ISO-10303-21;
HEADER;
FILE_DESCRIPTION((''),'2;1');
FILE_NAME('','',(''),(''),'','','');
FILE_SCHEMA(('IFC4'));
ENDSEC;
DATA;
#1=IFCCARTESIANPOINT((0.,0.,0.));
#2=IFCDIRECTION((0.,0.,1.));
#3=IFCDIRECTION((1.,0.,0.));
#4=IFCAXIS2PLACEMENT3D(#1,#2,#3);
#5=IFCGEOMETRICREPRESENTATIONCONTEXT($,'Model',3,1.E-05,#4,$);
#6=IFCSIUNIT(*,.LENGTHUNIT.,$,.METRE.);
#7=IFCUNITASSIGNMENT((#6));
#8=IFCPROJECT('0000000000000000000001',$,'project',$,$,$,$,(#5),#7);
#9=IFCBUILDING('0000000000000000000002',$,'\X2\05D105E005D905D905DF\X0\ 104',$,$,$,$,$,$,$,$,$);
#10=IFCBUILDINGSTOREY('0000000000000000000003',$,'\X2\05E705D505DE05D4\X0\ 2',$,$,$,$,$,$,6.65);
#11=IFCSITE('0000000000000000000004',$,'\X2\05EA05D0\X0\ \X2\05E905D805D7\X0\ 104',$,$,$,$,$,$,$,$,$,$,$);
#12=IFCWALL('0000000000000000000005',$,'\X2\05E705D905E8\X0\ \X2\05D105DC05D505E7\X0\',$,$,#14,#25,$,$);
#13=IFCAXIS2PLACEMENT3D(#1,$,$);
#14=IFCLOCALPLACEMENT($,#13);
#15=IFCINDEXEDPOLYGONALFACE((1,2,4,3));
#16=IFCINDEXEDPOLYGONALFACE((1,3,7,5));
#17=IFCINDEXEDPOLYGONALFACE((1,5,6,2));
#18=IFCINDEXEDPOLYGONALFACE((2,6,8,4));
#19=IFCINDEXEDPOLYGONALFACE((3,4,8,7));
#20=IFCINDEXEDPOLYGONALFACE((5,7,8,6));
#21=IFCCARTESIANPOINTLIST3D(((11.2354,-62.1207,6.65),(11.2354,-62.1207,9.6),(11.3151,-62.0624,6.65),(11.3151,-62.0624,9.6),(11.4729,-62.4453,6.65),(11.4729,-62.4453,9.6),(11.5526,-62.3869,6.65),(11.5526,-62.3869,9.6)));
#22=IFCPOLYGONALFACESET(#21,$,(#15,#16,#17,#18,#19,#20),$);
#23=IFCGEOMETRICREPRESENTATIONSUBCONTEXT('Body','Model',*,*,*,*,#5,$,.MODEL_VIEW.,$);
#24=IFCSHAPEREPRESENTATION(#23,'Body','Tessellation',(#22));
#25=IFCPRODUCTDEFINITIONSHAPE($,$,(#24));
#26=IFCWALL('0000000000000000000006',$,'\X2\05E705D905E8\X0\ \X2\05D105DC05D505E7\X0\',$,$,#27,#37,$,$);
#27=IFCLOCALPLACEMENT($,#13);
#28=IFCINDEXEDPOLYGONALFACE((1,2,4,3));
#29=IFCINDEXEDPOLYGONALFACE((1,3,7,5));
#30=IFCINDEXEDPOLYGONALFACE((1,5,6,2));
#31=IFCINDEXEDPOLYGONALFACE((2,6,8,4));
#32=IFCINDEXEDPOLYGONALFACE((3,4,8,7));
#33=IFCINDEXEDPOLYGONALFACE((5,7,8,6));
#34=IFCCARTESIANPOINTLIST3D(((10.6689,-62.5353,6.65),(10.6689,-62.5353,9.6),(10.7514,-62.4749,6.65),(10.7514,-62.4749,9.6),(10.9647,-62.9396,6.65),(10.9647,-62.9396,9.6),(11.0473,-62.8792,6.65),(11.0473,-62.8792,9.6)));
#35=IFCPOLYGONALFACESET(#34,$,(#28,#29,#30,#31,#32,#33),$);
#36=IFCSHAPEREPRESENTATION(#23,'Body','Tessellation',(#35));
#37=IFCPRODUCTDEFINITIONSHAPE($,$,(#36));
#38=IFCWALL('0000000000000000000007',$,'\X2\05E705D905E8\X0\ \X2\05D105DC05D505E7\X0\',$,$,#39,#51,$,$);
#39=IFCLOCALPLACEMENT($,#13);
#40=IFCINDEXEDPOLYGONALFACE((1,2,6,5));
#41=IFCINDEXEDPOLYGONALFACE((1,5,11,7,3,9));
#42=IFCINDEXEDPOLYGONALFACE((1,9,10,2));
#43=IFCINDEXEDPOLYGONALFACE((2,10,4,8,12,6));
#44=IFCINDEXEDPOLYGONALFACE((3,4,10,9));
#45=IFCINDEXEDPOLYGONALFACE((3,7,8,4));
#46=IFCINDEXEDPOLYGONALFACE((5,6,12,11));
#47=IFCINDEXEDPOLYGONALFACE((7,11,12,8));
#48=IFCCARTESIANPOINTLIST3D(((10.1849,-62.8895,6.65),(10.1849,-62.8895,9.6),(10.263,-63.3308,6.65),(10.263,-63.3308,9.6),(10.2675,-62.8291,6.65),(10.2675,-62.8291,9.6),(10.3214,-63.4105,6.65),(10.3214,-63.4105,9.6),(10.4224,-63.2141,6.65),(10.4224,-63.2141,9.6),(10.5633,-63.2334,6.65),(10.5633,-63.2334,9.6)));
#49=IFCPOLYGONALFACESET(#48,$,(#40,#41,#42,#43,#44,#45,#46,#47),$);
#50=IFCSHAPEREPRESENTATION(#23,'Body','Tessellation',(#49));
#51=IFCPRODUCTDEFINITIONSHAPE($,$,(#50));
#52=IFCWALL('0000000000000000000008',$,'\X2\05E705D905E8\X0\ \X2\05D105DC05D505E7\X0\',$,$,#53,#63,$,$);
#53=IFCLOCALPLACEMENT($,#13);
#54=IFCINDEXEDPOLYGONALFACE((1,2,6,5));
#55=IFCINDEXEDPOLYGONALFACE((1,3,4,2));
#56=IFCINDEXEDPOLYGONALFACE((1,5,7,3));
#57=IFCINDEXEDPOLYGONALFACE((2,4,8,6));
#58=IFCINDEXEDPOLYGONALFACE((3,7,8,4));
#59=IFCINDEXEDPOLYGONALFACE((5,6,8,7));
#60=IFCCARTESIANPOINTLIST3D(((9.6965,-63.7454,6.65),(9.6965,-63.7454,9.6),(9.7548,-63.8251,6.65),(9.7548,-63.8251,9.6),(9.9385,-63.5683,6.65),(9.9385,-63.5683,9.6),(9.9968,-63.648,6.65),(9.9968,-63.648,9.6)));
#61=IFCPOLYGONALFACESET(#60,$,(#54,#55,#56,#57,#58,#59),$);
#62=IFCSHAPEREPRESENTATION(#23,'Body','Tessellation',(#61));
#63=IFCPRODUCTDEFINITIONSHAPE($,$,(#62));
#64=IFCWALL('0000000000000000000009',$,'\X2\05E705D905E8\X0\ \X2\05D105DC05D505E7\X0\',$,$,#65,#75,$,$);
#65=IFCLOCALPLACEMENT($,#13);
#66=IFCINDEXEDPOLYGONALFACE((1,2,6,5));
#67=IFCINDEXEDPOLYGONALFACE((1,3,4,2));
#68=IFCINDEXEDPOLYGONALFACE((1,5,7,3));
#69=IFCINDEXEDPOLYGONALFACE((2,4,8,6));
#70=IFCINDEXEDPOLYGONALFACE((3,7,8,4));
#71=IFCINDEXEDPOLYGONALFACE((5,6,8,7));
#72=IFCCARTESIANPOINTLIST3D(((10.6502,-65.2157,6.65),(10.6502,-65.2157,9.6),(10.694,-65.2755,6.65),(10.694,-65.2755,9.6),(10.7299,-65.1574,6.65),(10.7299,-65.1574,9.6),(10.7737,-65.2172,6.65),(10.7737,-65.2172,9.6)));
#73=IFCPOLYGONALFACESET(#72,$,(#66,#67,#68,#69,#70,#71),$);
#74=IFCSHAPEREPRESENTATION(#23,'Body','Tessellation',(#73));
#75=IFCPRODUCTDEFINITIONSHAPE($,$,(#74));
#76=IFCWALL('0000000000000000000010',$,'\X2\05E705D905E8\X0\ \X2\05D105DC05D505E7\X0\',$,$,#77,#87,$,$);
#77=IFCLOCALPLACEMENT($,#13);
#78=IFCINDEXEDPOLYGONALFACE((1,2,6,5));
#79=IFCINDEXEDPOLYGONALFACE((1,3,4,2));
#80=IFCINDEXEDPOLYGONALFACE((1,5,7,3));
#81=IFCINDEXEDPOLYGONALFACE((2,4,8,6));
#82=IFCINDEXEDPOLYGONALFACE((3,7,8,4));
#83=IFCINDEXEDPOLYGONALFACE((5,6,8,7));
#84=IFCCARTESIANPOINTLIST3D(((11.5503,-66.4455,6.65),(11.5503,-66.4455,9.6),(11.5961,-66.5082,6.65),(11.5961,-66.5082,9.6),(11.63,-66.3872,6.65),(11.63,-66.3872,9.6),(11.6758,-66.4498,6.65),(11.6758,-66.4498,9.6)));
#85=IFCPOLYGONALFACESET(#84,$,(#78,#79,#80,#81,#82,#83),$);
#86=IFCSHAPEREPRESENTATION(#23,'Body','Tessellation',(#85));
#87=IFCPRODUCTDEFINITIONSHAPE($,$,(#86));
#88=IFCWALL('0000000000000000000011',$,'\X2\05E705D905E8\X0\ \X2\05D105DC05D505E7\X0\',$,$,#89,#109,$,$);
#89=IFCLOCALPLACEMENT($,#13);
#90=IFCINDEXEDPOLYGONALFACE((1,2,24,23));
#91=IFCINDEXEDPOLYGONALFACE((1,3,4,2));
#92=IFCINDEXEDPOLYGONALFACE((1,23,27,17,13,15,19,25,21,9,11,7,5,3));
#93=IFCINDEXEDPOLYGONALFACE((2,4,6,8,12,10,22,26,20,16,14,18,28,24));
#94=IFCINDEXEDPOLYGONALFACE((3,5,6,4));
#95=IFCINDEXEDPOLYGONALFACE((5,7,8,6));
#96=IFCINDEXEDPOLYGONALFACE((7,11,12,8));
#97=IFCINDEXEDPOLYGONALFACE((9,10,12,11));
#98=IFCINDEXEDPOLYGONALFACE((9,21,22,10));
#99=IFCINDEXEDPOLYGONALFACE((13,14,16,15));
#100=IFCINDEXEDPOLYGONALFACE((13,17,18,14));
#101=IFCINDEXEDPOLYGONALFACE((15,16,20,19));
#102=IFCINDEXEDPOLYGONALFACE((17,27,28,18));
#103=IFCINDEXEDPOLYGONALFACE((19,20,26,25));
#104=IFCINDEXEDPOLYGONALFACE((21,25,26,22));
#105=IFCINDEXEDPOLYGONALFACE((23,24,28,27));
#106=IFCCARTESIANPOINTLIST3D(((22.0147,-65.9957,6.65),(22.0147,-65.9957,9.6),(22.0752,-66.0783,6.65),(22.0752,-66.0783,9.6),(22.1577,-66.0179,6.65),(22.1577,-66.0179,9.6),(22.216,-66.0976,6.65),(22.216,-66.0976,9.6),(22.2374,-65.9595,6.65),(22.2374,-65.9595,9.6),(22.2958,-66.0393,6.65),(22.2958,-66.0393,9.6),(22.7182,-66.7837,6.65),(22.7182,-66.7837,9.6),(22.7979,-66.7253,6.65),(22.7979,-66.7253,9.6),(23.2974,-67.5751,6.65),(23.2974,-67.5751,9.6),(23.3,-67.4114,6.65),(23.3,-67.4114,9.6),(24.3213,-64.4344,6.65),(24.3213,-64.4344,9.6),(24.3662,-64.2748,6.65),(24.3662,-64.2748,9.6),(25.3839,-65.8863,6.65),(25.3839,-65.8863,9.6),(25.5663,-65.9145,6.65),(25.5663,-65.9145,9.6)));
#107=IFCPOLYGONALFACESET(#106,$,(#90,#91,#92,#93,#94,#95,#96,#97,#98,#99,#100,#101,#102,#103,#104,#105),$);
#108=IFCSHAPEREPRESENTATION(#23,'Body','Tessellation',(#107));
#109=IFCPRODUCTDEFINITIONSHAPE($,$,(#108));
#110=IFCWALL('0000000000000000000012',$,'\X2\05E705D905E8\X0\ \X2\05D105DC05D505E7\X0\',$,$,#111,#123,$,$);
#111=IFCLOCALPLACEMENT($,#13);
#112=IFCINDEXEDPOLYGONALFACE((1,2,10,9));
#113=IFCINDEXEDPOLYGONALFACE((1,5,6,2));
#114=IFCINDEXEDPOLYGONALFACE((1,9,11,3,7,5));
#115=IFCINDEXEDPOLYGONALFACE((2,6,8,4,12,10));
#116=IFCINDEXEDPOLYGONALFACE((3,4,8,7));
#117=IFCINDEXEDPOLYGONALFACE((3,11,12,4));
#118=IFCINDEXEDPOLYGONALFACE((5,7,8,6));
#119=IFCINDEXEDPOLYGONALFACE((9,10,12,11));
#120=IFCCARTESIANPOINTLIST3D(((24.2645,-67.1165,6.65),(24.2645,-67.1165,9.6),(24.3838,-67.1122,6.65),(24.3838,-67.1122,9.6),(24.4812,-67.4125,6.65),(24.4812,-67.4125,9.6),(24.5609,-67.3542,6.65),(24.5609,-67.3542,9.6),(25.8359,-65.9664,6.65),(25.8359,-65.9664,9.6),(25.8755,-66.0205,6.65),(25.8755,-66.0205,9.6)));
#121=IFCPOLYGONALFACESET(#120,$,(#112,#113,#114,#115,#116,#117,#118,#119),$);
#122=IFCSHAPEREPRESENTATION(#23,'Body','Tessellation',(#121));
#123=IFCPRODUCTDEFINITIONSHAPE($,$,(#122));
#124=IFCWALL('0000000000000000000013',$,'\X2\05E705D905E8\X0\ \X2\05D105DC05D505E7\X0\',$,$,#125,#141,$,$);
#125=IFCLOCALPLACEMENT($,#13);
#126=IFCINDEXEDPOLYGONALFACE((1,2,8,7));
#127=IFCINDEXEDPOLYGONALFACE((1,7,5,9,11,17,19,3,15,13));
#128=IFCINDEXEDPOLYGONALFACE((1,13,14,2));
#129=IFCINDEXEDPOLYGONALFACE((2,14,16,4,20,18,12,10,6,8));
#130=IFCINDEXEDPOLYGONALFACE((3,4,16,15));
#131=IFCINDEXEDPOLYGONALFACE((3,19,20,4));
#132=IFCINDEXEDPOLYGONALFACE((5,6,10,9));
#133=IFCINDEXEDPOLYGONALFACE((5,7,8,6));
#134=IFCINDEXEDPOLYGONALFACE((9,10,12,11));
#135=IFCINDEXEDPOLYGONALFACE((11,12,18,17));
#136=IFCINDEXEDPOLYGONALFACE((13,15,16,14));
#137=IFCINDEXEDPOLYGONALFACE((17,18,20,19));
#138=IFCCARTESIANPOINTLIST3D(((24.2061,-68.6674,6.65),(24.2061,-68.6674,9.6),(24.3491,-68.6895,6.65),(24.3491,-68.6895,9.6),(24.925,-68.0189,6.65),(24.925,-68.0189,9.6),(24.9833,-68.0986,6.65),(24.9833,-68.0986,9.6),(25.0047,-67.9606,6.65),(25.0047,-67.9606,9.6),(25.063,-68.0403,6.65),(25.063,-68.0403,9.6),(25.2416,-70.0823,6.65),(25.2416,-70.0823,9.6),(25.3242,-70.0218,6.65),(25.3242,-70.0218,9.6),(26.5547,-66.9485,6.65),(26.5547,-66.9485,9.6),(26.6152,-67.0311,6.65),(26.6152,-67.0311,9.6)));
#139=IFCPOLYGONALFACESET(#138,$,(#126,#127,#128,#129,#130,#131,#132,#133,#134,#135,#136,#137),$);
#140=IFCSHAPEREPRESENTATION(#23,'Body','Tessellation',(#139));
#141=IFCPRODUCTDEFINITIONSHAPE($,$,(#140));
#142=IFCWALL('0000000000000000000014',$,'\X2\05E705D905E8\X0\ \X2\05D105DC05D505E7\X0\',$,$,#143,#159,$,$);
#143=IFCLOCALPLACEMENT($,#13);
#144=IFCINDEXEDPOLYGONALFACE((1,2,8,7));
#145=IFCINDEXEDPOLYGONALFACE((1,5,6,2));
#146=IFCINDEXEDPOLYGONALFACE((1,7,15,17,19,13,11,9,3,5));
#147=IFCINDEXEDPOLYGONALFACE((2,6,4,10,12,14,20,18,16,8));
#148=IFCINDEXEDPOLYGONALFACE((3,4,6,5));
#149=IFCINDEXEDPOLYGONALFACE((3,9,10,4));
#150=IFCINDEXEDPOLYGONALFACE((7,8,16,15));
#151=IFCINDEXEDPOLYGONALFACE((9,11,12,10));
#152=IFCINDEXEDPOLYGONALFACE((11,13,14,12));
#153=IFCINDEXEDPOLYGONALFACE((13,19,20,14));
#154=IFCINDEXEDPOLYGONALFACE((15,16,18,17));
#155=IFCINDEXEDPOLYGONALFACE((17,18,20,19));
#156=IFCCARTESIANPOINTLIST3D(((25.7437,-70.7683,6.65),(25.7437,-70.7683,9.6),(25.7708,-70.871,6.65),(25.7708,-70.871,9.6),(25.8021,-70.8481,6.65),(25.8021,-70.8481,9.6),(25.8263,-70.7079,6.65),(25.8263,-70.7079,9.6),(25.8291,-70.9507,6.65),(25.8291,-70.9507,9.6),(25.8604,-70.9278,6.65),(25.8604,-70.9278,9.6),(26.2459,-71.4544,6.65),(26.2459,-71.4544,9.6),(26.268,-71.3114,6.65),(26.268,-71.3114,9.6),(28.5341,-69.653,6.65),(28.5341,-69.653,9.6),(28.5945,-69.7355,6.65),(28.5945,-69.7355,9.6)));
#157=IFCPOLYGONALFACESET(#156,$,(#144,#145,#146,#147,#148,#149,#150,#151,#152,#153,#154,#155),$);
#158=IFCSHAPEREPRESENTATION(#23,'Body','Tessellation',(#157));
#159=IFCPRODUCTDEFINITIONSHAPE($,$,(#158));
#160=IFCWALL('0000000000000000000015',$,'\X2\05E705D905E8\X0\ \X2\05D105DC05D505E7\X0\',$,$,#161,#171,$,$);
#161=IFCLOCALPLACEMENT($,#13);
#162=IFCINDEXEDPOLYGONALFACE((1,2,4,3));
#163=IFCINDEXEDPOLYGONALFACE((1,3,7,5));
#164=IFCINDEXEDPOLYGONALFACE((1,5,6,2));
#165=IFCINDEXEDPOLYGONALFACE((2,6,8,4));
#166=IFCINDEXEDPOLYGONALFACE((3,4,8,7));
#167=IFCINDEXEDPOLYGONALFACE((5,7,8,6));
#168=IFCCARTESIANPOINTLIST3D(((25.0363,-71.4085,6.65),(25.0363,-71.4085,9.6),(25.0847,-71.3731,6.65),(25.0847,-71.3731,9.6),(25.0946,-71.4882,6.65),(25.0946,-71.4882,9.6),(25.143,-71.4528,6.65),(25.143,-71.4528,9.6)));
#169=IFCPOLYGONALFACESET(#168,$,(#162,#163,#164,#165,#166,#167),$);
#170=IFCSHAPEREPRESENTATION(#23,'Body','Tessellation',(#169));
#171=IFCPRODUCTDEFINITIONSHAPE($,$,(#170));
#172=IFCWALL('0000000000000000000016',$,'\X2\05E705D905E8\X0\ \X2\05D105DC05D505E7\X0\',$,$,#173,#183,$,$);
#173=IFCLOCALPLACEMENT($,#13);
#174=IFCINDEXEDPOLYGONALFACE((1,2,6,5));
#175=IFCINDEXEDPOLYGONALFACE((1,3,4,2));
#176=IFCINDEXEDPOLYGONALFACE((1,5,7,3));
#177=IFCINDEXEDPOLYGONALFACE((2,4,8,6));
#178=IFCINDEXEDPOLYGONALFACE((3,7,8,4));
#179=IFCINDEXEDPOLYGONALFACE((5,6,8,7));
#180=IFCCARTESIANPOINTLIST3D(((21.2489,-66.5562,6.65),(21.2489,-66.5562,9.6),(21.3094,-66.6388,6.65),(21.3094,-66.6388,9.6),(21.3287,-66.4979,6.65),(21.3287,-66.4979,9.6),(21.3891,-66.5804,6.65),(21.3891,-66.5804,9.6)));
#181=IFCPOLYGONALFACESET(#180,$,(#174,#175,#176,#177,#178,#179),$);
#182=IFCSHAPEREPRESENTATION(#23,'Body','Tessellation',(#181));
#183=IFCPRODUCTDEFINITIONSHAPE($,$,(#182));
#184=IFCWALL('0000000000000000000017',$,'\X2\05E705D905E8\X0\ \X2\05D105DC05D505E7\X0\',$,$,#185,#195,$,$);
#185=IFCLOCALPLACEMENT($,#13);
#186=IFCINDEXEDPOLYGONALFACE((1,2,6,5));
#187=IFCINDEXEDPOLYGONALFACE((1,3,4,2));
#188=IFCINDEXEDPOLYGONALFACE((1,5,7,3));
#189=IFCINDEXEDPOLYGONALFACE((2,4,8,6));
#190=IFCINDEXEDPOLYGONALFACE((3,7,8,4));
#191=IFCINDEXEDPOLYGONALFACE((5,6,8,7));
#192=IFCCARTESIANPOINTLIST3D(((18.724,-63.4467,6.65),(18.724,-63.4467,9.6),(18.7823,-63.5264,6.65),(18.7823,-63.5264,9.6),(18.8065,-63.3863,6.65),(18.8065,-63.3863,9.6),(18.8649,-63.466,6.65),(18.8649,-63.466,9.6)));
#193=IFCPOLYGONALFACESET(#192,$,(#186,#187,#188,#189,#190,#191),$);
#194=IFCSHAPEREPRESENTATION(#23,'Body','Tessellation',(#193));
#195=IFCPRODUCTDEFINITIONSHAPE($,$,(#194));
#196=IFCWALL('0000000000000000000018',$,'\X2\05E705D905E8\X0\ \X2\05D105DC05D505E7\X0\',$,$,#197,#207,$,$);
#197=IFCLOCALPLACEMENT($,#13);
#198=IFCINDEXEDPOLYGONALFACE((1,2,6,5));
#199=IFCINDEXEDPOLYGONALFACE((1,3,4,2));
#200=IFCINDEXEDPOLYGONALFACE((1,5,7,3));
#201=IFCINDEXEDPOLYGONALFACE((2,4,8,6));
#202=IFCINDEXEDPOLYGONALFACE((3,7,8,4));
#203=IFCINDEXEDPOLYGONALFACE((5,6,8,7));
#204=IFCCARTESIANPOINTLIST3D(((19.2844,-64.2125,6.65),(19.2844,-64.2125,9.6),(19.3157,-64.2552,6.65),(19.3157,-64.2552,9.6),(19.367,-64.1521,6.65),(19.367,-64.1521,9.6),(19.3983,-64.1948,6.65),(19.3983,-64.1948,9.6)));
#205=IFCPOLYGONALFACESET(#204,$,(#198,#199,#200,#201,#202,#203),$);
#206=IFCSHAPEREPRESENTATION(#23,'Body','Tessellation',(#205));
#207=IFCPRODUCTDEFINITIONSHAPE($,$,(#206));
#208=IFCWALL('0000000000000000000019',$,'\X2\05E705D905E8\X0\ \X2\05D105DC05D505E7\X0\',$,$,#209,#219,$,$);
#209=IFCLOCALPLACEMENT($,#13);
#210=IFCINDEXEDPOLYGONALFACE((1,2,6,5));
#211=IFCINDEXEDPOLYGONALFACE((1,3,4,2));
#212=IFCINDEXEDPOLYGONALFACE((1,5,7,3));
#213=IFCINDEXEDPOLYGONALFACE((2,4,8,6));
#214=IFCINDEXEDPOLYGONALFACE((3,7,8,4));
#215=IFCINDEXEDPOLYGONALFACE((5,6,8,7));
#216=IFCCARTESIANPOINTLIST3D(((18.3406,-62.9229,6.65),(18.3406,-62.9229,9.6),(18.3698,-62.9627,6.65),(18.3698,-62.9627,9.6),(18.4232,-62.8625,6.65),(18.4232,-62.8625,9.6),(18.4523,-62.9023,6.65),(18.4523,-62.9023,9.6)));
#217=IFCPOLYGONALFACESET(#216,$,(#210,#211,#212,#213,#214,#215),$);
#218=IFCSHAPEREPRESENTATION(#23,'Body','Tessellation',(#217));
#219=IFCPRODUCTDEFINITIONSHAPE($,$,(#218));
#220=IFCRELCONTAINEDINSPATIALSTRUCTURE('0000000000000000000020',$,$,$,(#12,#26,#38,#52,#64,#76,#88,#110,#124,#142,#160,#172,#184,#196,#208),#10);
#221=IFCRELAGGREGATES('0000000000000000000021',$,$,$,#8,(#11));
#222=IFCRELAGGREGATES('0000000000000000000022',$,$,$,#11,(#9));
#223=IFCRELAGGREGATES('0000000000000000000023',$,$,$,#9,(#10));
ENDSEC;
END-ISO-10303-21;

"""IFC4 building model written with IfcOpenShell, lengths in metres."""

from ifc_helpers import new_model, si_unit, frame, origin_with_axes, context, subcontext, project, spatial, polyline, outline, extrude, element, save


model = new_model("IFC4")

# Units and contexts
model_context = context("Model", 3, precision=1e-05, world=origin_with_axes())
body_context = subcontext(model_context, "Body", "Model", "MODEL_VIEW")
ifc_project = project(units=[si_unit("LENGTHUNIT", "METRE")], contexts=[model_context])

# Site, building, storey
site = spatial("IfcSite", under=ifc_project, Name="תא שטח 104")
building = spatial("IfcBuilding", under=site, Name="בניין 104")
storey = spatial("IfcBuildingStorey", under=building, Name="קומה 2", Elevation=6.65)

# Walls
element("IfcWall", 1, inside=storey, Name="קיר בלוק", context=body_context, shape_type="SweptSolid", body=[
    extrude(outline(polyline([(11.3151, -62.0624), (11.2354, -62.1207), (11.4729, -62.4453), (11.5526, -62.3869), (11.3151, -62.0624)])), frame((0.0, 0.0, 6.65)), (0.0, 0.0, 1.0), 2.95),
])
element("IfcWall", 2, inside=storey, Name="קיר בלוק", context=body_context, shape_type="SweptSolid", body=[
    extrude(outline(polyline([(10.6689, -62.5353), (10.9647, -62.9396), (11.0473, -62.8792), (10.7514, -62.4749), (10.6689, -62.5353)])), frame((0.0, 0.0, 6.65)), (0.0, 0.0, 1.0), 2.95),
])
element("IfcWall", 3, inside=storey, Name="קיר בלוק", context=body_context, shape_type="SweptSolid", body=[
    extrude(outline(polyline([(10.1849, -62.8895), (10.4224, -63.2141), (10.263, -63.3308), (10.3214, -63.4105), (10.5633, -63.2334), (10.2675, -62.8291), (10.1849, -62.8895)])), frame((0.0, 0.0, 6.65)), (0.0, 0.0, 1.0), 2.95),
])
element("IfcWall", 4, inside=storey, Name="קיר בלוק", context=body_context, shape_type="SweptSolid", body=[
    extrude(outline(polyline([(9.9968, -63.648), (9.9385, -63.5683), (9.6965, -63.7454), (9.7548, -63.8251), (9.9968, -63.648)])), frame((0.0, 0.0, 6.65)), (0.0, 0.0, 1.0), 2.95),
])
element("IfcWall", 5, inside=storey, Name="קיר בלוק", context=body_context, shape_type="SweptSolid", body=[
    extrude(outline(polyline([(10.7737, -65.2172), (10.7299, -65.1574), (10.6502, -65.2157), (10.694, -65.2755), (10.7737, -65.2172)])), frame((0.0, 0.0, 6.65)), (0.0, 0.0, 1.0), 2.95),
])
element("IfcWall", 6, inside=storey, Name="קיר בלוק", context=body_context, shape_type="SweptSolid", body=[
    extrude(outline(polyline([(11.6758, -66.4498), (11.63, -66.3872), (11.5503, -66.4455), (11.5961, -66.5082), (11.6758, -66.4498)])), frame((0.0, 0.0, 6.65)), (0.0, 0.0, 1.0), 2.95),
])
element("IfcWall", 7, inside=storey, Name="קיר בלוק", context=body_context, shape_type="SweptSolid", body=[
    extrude(outline(polyline([(22.7979, -66.7253), (22.7182, -66.7837), (23.2974, -67.5751), (25.5663, -65.9145), (24.3662, -64.2748), (22.0147, -65.9957), (22.0752, -66.0783), (22.1577, -66.0179), (22.216, -66.0976), (22.2958, -66.0393), (22.2374, -65.9595), (24.3213, -64.4344), (25.3839, -65.8863), (23.3, -67.4114), (22.7979, -66.7253)])), frame((0.0, 0.0, 6.65)), (0.0, 0.0, 1.0), 2.95),
])
element("IfcWall", 8, inside=storey, Name="קיר בלוק", context=body_context, shape_type="SweptSolid", body=[
    extrude(outline(polyline([(24.2645, -67.1165), (24.4812, -67.4125), (24.5609, -67.3542), (24.3838, -67.1122), (25.8755, -66.0205), (25.8359, -65.9664), (24.2645, -67.1165)])), frame((0.0, 0.0, 6.65)), (0.0, 0.0, 1.0), 2.95),
])
element("IfcWall", 9, inside=storey, Name="קיר בלוק", context=body_context, shape_type="SweptSolid", body=[
    extrude(outline(polyline([(24.9833, -68.0986), (24.2061, -68.6674), (25.2416, -70.0823), (25.3242, -70.0218), (24.3491, -68.6895), (26.6152, -67.0311), (26.5547, -66.9485), (25.063, -68.0403), (25.0047, -67.9606), (24.925, -68.0189), (24.9833, -68.0986)])), frame((0.0, 0.0, 6.65)), (0.0, 0.0, 1.0), 2.95),
])
element("IfcWall", 10, inside=storey, Name="קיר בלוק", context=body_context, shape_type="SweptSolid", body=[
    extrude(outline(polyline([(25.8604, -70.9278), (26.2459, -71.4544), (28.5945, -69.7355), (28.5341, -69.653), (26.268, -71.3114), (25.8263, -70.7079), (25.7437, -70.7683), (25.8021, -70.8481), (25.7708, -70.871), (25.8291, -70.9507), (25.8604, -70.9278)])), frame((0.0, 0.0, 6.65)), (0.0, 0.0, 1.0), 2.95),
])
element("IfcWall", 11, inside=storey, Name="קיר בלוק", context=body_context, shape_type="SweptSolid", body=[
    extrude(outline(polyline([(25.0847, -71.3731), (25.0363, -71.4085), (25.0946, -71.4882), (25.143, -71.4528), (25.0847, -71.3731)])), frame((0.0, 0.0, 6.65)), (0.0, 0.0, 1.0), 2.95),
])
element("IfcWall", 12, inside=storey, Name="קיר בלוק", context=body_context, shape_type="SweptSolid", body=[
    extrude(outline(polyline([(21.3891, -66.5804), (21.3287, -66.4979), (21.2489, -66.5562), (21.3094, -66.6388), (21.3891, -66.5804)])), frame((0.0, 0.0, 6.65)), (0.0, 0.0, 1.0), 2.95),
])
element("IfcWall", 13, inside=storey, Name="קיר בלוק", context=body_context, shape_type="SweptSolid", body=[
    extrude(outline(polyline([(18.7823, -63.5264), (18.8649, -63.466), (18.8065, -63.3863), (18.724, -63.4467), (18.7823, -63.5264)])), frame((0.0, 0.0, 6.65)), (0.0, 0.0, 1.0), 2.95),
])
element("IfcWall", 14, inside=storey, Name="קיר בלוק", context=body_context, shape_type="SweptSolid", body=[
    extrude(outline(polyline([(19.3983, -64.1948), (19.367, -64.1521), (19.2844, -64.2125), (19.3157, -64.2552), (19.3983, -64.1948)])), frame((0.0, 0.0, 6.65)), (0.0, 0.0, 1.0), 2.95),
])
element("IfcWall", 15, inside=storey, Name="קיר בלוק", context=body_context, shape_type="SweptSolid", body=[
    extrude(outline(polyline([(18.3406, -62.9229), (18.3698, -62.9627), (18.4523, -62.9023), (18.4232, -62.8625), (18.3406, -62.9229)])), frame((0.0, 0.0, 6.65)), (0.0, 0.0, 1.0), 2.95),
])

save(model, "model.ifc")
